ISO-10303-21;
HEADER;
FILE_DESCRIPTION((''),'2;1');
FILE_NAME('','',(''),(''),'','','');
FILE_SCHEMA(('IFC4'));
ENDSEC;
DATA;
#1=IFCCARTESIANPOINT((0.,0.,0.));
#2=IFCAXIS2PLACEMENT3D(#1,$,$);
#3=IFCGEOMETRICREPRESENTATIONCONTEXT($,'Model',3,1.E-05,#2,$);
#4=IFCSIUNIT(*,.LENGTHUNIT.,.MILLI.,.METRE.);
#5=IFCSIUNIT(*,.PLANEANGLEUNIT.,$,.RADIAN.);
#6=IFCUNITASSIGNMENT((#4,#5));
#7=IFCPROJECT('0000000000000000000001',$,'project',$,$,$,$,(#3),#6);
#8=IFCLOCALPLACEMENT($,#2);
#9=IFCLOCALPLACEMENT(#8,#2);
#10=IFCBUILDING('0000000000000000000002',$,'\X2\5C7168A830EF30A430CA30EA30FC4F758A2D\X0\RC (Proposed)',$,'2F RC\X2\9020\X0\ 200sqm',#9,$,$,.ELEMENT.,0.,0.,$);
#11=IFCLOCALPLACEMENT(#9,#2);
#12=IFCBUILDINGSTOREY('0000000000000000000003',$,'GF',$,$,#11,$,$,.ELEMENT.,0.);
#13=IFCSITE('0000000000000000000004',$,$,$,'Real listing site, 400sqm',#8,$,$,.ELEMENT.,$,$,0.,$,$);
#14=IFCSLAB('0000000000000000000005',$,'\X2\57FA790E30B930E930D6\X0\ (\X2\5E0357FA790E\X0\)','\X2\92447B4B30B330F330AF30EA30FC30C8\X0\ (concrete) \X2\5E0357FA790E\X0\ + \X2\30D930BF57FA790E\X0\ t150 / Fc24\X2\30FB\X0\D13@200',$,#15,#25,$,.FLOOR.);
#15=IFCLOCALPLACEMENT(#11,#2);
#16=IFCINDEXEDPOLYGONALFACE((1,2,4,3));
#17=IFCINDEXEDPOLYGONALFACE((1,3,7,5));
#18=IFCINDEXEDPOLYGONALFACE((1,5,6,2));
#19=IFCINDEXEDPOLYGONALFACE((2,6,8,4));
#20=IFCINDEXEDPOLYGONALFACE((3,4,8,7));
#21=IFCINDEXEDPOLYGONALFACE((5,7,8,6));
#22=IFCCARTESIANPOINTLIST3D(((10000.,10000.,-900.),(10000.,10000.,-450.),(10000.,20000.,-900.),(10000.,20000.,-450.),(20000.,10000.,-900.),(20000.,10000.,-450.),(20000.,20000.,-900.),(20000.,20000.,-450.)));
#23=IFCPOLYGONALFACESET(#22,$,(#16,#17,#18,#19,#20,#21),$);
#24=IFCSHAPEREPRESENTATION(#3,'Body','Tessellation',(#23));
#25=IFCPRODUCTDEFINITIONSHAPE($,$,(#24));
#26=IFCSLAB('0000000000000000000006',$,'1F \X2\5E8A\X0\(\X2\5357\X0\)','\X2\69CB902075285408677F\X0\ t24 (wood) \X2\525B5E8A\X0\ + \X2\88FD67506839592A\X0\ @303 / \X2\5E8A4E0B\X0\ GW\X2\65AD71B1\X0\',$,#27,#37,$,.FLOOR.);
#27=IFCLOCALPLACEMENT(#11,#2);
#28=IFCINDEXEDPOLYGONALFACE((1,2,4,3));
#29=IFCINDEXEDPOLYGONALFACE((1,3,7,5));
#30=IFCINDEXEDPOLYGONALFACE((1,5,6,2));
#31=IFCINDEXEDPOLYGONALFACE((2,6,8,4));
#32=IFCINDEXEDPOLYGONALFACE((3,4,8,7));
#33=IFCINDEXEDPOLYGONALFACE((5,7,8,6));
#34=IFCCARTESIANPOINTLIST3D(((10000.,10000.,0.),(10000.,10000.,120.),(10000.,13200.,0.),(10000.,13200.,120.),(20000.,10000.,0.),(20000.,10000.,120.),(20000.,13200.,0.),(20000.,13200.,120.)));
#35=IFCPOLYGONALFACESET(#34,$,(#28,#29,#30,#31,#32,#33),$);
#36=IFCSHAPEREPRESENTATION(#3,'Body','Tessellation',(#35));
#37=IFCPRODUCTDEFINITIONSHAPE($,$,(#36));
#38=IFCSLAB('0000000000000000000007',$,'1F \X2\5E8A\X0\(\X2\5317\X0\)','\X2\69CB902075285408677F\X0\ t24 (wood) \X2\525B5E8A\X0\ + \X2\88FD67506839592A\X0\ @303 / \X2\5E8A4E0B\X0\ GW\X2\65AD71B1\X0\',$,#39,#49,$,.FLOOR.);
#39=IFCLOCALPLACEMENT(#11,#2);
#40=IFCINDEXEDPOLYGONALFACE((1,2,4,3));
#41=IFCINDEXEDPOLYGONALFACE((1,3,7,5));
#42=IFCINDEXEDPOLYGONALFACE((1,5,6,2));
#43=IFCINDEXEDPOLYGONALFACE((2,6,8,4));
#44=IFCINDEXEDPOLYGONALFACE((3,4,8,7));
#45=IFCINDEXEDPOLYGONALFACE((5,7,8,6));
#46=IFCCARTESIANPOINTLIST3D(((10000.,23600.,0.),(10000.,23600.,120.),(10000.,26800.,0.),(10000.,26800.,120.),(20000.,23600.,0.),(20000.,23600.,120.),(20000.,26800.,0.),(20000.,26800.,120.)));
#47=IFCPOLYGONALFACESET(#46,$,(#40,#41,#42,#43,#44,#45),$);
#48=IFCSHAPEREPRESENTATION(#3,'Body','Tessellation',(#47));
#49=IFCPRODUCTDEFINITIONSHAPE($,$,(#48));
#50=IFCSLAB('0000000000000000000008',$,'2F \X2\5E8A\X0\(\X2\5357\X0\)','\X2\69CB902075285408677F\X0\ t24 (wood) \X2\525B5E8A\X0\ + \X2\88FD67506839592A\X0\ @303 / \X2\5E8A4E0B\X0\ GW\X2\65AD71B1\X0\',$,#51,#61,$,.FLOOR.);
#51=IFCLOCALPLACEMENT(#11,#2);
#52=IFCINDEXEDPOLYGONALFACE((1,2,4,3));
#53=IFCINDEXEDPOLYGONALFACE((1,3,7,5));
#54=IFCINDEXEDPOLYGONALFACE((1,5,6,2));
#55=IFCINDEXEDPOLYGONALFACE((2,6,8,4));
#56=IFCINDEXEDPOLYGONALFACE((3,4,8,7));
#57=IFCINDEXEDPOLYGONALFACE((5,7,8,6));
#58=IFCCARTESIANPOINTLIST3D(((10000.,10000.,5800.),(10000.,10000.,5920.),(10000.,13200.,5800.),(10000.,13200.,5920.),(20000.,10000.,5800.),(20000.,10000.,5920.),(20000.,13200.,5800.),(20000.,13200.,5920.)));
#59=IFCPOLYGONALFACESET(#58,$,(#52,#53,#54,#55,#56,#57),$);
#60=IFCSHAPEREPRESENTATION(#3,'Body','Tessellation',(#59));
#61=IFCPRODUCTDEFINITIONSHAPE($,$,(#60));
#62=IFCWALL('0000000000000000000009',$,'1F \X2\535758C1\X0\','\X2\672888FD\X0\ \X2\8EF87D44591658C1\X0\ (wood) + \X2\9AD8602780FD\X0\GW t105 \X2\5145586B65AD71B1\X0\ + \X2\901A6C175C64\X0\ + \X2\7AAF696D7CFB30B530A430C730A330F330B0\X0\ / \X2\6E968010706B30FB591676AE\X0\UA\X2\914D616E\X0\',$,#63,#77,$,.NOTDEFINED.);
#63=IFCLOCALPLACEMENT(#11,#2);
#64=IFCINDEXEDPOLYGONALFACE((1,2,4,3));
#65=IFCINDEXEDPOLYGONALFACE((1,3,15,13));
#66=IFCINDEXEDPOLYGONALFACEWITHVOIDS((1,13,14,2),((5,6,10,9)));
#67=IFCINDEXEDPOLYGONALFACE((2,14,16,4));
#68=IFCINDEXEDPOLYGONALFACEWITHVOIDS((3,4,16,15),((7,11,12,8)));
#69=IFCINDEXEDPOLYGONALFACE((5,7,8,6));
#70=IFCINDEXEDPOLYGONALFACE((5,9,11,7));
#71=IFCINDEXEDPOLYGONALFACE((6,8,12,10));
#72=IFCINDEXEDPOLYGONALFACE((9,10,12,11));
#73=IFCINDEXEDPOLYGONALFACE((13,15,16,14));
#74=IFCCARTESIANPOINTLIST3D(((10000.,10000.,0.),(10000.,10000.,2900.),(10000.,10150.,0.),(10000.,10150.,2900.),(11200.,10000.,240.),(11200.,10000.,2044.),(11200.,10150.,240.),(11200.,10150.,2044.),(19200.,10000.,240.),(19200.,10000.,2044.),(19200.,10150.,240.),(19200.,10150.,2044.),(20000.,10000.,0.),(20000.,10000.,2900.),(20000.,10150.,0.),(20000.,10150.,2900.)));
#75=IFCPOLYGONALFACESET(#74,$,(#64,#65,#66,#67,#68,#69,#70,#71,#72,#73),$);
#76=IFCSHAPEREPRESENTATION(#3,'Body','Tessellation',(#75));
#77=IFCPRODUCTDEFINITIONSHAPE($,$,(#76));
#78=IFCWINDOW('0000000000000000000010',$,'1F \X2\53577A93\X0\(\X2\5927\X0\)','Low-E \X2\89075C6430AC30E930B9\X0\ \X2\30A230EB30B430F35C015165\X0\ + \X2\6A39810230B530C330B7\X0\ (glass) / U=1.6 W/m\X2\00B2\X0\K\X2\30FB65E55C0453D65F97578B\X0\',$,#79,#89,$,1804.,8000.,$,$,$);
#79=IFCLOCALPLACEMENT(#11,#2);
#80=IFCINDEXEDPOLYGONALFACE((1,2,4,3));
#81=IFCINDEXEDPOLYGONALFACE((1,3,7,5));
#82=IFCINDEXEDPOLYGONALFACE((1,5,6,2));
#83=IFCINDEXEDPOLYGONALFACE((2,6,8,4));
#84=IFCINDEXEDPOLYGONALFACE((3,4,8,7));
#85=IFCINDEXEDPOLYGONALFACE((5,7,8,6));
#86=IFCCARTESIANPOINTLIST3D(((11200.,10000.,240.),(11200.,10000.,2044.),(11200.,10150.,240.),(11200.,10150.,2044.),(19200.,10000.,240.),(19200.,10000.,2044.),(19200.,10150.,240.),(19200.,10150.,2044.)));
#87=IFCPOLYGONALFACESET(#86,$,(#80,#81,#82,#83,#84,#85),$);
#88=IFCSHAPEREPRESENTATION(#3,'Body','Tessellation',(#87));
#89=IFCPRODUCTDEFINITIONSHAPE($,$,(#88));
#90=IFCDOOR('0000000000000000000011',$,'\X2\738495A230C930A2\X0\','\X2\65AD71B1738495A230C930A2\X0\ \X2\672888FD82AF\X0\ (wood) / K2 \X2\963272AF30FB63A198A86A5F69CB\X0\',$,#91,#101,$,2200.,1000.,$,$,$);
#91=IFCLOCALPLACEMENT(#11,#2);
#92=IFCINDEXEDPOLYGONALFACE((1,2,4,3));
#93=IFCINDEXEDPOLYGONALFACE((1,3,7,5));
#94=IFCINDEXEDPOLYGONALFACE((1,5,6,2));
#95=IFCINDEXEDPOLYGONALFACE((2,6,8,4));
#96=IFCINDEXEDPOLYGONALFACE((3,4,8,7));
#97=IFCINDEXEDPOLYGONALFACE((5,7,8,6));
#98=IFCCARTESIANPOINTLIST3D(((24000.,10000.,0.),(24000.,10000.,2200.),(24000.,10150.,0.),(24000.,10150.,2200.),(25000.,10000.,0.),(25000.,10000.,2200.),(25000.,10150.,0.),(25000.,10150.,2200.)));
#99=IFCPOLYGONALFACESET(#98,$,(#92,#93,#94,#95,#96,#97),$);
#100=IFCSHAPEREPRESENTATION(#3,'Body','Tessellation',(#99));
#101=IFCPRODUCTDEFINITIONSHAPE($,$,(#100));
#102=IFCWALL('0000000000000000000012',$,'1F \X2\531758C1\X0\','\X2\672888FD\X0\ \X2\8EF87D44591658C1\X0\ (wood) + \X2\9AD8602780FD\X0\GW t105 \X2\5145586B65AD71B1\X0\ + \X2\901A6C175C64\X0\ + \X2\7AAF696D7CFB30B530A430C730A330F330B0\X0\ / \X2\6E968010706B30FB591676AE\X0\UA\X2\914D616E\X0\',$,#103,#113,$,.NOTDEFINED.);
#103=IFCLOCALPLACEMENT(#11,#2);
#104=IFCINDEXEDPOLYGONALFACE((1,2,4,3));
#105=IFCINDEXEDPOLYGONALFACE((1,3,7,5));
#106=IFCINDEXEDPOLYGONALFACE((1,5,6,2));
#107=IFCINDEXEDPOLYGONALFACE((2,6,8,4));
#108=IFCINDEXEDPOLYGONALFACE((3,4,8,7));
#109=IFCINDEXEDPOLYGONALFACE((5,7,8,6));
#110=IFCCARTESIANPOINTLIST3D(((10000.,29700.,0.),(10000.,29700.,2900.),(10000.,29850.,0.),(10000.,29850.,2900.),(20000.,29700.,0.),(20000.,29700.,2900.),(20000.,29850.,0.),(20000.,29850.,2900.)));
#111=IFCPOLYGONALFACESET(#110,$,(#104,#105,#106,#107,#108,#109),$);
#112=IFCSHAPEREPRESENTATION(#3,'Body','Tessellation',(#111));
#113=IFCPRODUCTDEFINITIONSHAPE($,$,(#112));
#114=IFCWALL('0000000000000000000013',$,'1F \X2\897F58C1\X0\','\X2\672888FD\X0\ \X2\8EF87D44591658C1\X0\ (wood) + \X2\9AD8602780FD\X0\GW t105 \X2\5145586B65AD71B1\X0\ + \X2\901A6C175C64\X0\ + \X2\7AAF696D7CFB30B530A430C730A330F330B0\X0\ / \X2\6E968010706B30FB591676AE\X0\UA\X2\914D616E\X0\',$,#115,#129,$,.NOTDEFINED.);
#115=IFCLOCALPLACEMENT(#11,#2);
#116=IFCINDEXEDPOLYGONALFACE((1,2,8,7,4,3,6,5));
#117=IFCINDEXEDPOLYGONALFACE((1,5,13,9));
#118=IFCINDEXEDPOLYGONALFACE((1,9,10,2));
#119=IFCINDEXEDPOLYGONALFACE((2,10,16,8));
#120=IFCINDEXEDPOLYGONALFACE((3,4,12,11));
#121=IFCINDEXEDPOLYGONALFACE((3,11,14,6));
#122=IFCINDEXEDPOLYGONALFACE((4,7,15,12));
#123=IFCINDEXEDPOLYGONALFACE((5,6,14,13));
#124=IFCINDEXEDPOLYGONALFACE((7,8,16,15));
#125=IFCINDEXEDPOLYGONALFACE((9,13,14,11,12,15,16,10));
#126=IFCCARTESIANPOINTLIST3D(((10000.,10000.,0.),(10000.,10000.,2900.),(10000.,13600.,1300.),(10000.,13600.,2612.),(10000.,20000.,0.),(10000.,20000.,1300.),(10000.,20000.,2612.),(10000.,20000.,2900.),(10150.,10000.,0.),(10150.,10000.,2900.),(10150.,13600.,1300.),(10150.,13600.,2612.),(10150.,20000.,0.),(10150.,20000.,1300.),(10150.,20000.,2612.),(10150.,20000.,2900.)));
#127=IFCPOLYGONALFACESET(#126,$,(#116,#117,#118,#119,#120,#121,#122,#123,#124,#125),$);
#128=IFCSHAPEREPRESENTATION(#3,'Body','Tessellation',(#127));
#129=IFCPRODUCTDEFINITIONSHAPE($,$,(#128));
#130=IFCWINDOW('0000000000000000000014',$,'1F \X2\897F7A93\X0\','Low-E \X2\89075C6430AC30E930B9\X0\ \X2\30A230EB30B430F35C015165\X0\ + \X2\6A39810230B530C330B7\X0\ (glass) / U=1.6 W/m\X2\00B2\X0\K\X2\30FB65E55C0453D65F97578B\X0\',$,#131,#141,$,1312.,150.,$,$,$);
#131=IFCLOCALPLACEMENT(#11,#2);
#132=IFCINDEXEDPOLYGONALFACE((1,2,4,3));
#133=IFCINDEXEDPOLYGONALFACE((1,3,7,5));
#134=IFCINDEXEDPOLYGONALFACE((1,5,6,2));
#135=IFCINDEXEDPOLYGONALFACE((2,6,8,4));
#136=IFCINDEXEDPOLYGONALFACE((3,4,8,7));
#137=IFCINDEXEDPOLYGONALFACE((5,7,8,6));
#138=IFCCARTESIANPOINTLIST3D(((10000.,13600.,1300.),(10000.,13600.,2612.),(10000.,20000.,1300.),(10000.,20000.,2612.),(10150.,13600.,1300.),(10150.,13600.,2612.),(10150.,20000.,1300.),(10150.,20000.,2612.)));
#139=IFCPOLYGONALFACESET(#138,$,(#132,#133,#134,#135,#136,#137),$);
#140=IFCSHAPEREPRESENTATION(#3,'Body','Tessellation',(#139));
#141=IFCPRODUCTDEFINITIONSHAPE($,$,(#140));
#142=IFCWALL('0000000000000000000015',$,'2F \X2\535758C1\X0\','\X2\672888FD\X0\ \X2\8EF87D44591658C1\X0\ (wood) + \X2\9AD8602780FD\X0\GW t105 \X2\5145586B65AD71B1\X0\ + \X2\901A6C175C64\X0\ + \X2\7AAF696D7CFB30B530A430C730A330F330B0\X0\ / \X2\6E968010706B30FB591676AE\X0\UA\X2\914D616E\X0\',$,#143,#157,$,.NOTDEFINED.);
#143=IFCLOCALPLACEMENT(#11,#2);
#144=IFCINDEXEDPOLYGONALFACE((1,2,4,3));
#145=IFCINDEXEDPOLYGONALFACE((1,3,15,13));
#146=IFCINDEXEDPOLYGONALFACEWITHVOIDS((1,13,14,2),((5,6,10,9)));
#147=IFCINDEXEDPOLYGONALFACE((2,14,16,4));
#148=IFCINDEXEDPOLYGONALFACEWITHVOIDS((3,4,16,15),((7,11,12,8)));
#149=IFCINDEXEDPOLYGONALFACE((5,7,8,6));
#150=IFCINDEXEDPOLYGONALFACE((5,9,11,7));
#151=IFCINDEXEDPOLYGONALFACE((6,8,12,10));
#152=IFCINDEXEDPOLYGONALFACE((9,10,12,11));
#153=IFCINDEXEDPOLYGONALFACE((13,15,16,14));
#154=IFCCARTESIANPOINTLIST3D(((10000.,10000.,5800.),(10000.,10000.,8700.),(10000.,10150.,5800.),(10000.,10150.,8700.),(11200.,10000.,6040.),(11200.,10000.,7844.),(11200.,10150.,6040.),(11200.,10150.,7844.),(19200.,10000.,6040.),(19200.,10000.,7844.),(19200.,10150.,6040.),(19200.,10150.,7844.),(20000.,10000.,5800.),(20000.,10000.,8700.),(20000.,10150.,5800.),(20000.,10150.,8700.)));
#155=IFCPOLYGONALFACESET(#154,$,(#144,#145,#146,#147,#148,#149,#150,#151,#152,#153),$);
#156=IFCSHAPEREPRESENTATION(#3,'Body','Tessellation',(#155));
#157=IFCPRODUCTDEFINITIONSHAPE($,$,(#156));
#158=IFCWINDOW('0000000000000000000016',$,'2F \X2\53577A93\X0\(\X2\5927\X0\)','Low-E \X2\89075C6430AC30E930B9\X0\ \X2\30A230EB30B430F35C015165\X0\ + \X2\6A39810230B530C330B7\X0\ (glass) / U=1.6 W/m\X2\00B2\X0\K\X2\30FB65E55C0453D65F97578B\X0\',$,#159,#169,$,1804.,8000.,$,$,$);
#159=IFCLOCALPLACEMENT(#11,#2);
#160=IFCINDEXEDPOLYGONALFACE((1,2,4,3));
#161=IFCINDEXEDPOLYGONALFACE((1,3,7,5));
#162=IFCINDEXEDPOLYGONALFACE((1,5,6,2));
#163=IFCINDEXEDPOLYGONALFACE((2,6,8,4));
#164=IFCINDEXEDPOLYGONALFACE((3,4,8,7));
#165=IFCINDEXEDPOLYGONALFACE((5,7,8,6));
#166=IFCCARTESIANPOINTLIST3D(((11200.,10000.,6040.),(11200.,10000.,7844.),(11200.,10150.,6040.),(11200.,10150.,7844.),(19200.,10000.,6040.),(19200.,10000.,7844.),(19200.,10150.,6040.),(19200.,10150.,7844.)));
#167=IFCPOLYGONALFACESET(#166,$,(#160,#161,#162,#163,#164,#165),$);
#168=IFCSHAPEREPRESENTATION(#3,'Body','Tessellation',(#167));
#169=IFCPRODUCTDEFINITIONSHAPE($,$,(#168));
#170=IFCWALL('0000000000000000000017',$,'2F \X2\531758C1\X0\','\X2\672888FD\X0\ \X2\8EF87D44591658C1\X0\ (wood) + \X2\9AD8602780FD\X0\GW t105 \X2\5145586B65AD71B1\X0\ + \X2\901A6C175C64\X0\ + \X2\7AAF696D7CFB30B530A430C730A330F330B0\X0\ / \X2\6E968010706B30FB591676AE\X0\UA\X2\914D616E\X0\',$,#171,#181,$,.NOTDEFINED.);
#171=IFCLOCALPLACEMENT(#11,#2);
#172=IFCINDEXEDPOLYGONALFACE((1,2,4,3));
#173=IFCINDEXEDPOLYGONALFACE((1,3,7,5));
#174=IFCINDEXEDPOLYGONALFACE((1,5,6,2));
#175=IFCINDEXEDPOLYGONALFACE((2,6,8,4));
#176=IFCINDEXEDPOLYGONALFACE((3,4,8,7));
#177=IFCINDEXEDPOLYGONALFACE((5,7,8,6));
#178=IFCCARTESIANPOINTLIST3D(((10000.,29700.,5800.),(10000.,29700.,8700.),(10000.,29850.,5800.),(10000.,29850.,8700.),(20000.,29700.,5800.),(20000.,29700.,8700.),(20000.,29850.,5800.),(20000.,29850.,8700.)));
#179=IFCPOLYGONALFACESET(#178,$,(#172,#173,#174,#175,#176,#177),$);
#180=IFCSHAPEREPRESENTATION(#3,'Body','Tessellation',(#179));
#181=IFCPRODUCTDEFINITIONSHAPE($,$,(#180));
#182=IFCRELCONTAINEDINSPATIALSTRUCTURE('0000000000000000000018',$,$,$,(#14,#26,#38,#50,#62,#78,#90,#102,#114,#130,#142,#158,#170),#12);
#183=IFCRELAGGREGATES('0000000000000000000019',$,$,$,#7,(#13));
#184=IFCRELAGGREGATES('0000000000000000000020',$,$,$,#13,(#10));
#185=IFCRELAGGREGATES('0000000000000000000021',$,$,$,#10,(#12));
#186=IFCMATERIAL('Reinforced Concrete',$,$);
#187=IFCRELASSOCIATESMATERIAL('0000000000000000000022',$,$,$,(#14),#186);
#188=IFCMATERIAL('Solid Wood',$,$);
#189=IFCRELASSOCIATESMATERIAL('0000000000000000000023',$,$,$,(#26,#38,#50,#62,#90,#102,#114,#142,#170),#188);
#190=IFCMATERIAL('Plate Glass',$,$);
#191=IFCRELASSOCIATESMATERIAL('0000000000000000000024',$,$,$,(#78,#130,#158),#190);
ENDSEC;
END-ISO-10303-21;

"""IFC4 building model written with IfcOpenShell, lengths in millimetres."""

from ifc_helpers import new_model, si_unit, frame, frame_2d, origin, place, context, project, spatial, rectangle, extrude, material, element, fill, save


model = new_model("IFC4")

# Units and contexts
model_context = context("Model", 3, precision=1e-05, world=origin())
ifc_project = project(units=[si_unit("LENGTHUNIT", "METRE", prefix="MILLI"), si_unit("PLANEANGLEUNIT", "RADIAN")], contexts=[model_context])

# Site, building, storey
site_placement = place(None, origin())
site = spatial("IfcSite", under=ifc_project, at=site_placement, ObjectType="Real listing site, 400sqm", CompositionType="ELEMENT", RefElevation=0.0)
building_placement = place(site_placement, origin())
building = spatial("IfcBuilding", under=site, at=building_placement, Name="山梨ワイナリー併設RC (Proposed)", ObjectType="2F RC造 200sqm", CompositionType="ELEMENT", ElevationOfRefHeight=0.0, ElevationOfTerrain=0.0)
storey_placement = place(building_placement, origin())
storey = spatial("IfcBuildingStorey", under=building, at=storey_placement, Name="GF", CompositionType="ELEMENT", Elevation=0.0)

# Slabs
ifc_material_1 = material(Name="Reinforced Concrete")
slab_1_placement = place(storey_placement, frame((5000.0, 5000.0, -450.0)))
element("IfcSlab", 1, at=slab_1_placement, inside=storey, material=ifc_material_1, Name="基礎スラブ (布基礎)", Description="鉄筋コンクリート (concrete) 布基礎 + ベタ基礎 t150 / Fc24・D13@200", PredefinedType="FLOOR", context=model_context, shape_type="SweptSolid", body=[
    extrude(rectangle(XDim=10000.0, YDim=10000.0, at=frame_2d((5000.0, 5000.0))), frame((5000.0, 5000.0, -450.0)), (0.0, 0.0, 1.0), 450.0),
])
ifc_material_2 = material(Name="Solid Wood")
slab_2_placement = place(storey_placement, frame((5000.0, 5000.0, 0.0)))
element("IfcSlab", 2, at=slab_2_placement, inside=storey, material=ifc_material_2, Name="1F 床(南)", Description="構造用合板 t24 (wood) 剛床 + 製材根太 @303 / 床下 GW断熱", PredefinedType="FLOOR", context=model_context, shape_type="SweptSolid", body=[
    extrude(rectangle(XDim=10000.0, YDim=3200.0, at=frame_2d((5000.0, 1600.0))), frame((5000.0, 5000.0, 0.0)), (0.0, 0.0, 1.0), 120.0),
])
slab_3_placement = place(storey_placement, frame((5000.0, 11800.0, 0.0)))
element("IfcSlab", 3, at=slab_3_placement, inside=storey, material=ifc_material_2, Name="1F 床(北)", Description="構造用合板 t24 (wood) 剛床 + 製材根太 @303 / 床下 GW断熱", PredefinedType="FLOOR", context=model_context, shape_type="SweptSolid", body=[
    extrude(rectangle(XDim=10000.0, YDim=3200.0, at=frame_2d((5000.0, 1600.0))), frame((5000.0, 11800.0, 0.0)), (0.0, 0.0, 1.0), 120.0),
])
slab_4_placement = place(storey_placement, frame((5000.0, 5000.0, 2900.0)))
element("IfcSlab", 4, at=slab_4_placement, inside=storey, material=ifc_material_2, Name="2F 床(南)", Description="構造用合板 t24 (wood) 剛床 + 製材根太 @303 / 床下 GW断熱", PredefinedType="FLOOR", context=model_context, shape_type="SweptSolid", body=[
    extrude(rectangle(XDim=10000.0, YDim=3200.0, at=frame_2d((5000.0, 1600.0))), frame((5000.0, 5000.0, 2900.0)), (0.0, 0.0, 1.0), 120.0),
])

# Wall, openings, window, door
wall_1_placement = place(storey_placement, frame((5000.0, 5000.0, 0.0)))
wall_1 = element("IfcWall", 5, at=wall_1_placement, inside=storey, material=ifc_material_2, Name="1F 南壁", Description="木製 軸組外壁 (wood) + 高性能GW t105 充填断熱 + 通気層 + 窯業系サイディング / 準耐火・外皮UA配慮", PredefinedType="NOTDEFINED", context=model_context, shape_type="SweptSolid", body=[
    extrude(rectangle(XDim=10000.0, YDim=150.0, at=frame_2d((5000.0, 75.0))), frame((5000.0, 5000.0, 0.0)), (0.0, 0.0, 1.0), 2900.0),
])
opening_1_placement = place(storey_placement, frame((5600.0, 5000.0, 120.0)))
opening_1 = element("IfcOpeningElement", 6, at=opening_1_placement, cuts=wall_1, PredefinedType="NOTDEFINED", context=model_context, shape_type="SweptSolid", body=[
    extrude(rectangle(XDim=8000.0, YDim=150.0, at=frame_2d((4000.0, 75.0))), frame((5600.0, 5000.0, 120.0)), (0.0, 0.0, 1.0), 1804.0),
])
opening_2_placement = place(storey_placement, frame((12000.0, 5000.0, 0.0)))
opening_2 = element("IfcOpeningElement", 7, at=opening_2_placement, cuts=wall_1, PredefinedType="NOTDEFINED", context=model_context, shape_type="SweptSolid", body=[
    extrude(rectangle(XDim=1000.0, YDim=150.0, at=frame_2d((500.0, 75.0))), frame((12000.0, 5000.0, 0.0)), (0.0, 0.0, 1.0), 2200.0),
])
ifc_material_3 = material(Name="Plate Glass")
window_1_placement = place(storey_placement, frame((5600.0, 5000.0, 120.0)))
window_1 = element("IfcWindow", 8, at=window_1_placement, inside=storey, material=ifc_material_3, Name="1F 南窓(大)", Description="Low-E 複層ガラス アルゴン封入 + 樹脂サッシ (glass) / U=1.6 W/m²K・日射取得型", OverallHeight=1804.0, OverallWidth=8000.0, context=model_context, shape_type="SweptSolid", body=[
    extrude(rectangle(XDim=8000.0, YDim=150.0, at=frame_2d((4000.0, 75.0))), frame((5600.0, 5000.0, 120.0)), (0.0, 0.0, 1.0), 1804.0),
])
fill(opening_1, window_1)
door_placement = place(storey_placement, frame((12000.0, 5000.0, 0.0)))
door = element("IfcDoor", 9, at=door_placement, inside=storey, material=ifc_material_2, Name="玄関ドア", Description="断熱玄関ドア 木製芯 (wood) / K2 防犯・採風機構", OverallHeight=2200.0, OverallWidth=1000.0, context=model_context, shape_type="SweptSolid", body=[
    extrude(rectangle(XDim=1000.0, YDim=150.0, at=frame_2d((500.0, 75.0))), frame((12000.0, 5000.0, 0.0)), (0.0, 0.0, 1.0), 2200.0),
])
fill(opening_2, door)

# Wall
wall_2_placement = place(storey_placement, frame((5000.0, 14850.0, 0.0)))
element("IfcWall", 10, at=wall_2_placement, inside=storey, material=ifc_material_2, Name="1F 北壁", Description="木製 軸組外壁 (wood) + 高性能GW t105 充填断熱 + 通気層 + 窯業系サイディング / 準耐火・外皮UA配慮", PredefinedType="NOTDEFINED", context=model_context, shape_type="SweptSolid", body=[
    extrude(rectangle(XDim=10000.0, YDim=150.0, at=frame_2d((5000.0, 75.0))), frame((5000.0, 14850.0, 0.0)), (0.0, 0.0, 1.0), 2900.0),
])

# Walls, openings, windows
wall_3_placement = place(storey_placement, frame((5000.0, 5000.0, 0.0)))
wall_3 = element("IfcWall", 11, at=wall_3_placement, inside=storey, material=ifc_material_2, Name="1F 西壁", Description="木製 軸組外壁 (wood) + 高性能GW t105 充填断熱 + 通気層 + 窯業系サイディング / 準耐火・外皮UA配慮", PredefinedType="NOTDEFINED", context=model_context, shape_type="SweptSolid", body=[
    extrude(rectangle(XDim=150.0, YDim=10000.0, at=frame_2d((75.0, 5000.0))), frame((5000.0, 5000.0, 0.0)), (0.0, 0.0, 1.0), 2900.0),
])
opening_3_placement = place(storey_placement, frame((5000.0, 6800.0, 650.0)))
opening_3 = element("IfcOpeningElement", 12, at=opening_3_placement, cuts=wall_3, PredefinedType="NOTDEFINED", context=model_context, shape_type="SweptSolid", body=[
    extrude(rectangle(XDim=150.0, YDim=6400.0, at=frame_2d((75.0, 3200.0))), frame((5000.0, 6800.0, 650.0)), (0.0, 0.0, 1.0), 1312.0),
])
window_2_placement = place(storey_placement, frame((5000.0, 6800.0, 650.0)))
window_2 = element("IfcWindow", 13, at=window_2_placement, inside=storey, material=ifc_material_3, Name="1F 西窓", Description="Low-E 複層ガラス アルゴン封入 + 樹脂サッシ (glass) / U=1.6 W/m²K・日射取得型", OverallHeight=1312.0, OverallWidth=150.0, context=model_context, shape_type="SweptSolid", body=[
    extrude(rectangle(XDim=150.0, YDim=6400.0, at=frame_2d((75.0, 3200.0))), frame((5000.0, 6800.0, 650.0)), (0.0, 0.0, 1.0), 1312.0),
])
fill(opening_3, window_2)
wall_4_placement = place(storey_placement, frame((5000.0, 5000.0, 2900.0)))
wall_4 = element("IfcWall", 14, at=wall_4_placement, inside=storey, material=ifc_material_2, Name="2F 南壁", Description="木製 軸組外壁 (wood) + 高性能GW t105 充填断熱 + 通気層 + 窯業系サイディング / 準耐火・外皮UA配慮", PredefinedType="NOTDEFINED", context=model_context, shape_type="SweptSolid", body=[
    extrude(rectangle(XDim=10000.0, YDim=150.0, at=frame_2d((5000.0, 75.0))), frame((5000.0, 5000.0, 2900.0)), (0.0, 0.0, 1.0), 2900.0),
])
opening_4_placement = place(storey_placement, frame((5600.0, 5000.0, 3020.0)))
opening_4 = element("IfcOpeningElement", 15, at=opening_4_placement, cuts=wall_4, PredefinedType="NOTDEFINED", context=model_context, shape_type="SweptSolid", body=[
    extrude(rectangle(XDim=8000.0, YDim=150.0, at=frame_2d((4000.0, 75.0))), frame((5600.0, 5000.0, 3020.0)), (0.0, 0.0, 1.0), 1804.0),
])
window_3_placement = place(storey_placement, frame((5600.0, 5000.0, 3020.0)))
window_3 = element("IfcWindow", 16, at=window_3_placement, inside=storey, material=ifc_material_3, Name="2F 南窓(大)", Description="Low-E 複層ガラス アルゴン封入 + 樹脂サッシ (glass) / U=1.6 W/m²K・日射取得型", OverallHeight=1804.0, OverallWidth=8000.0, context=model_context, shape_type="SweptSolid", body=[
    extrude(rectangle(XDim=8000.0, YDim=150.0, at=frame_2d((4000.0, 75.0))), frame((5600.0, 5000.0, 3020.0)), (0.0, 0.0, 1.0), 1804.0),
])
fill(opening_4, window_3)

# Wall
wall_5_placement = place(storey_placement, frame((5000.0, 14850.0, 2900.0)))
element("IfcWall", 17, at=wall_5_placement, inside=storey, material=ifc_material_2, Name="2F 北壁", Description="木製 軸組外壁 (wood) + 高性能GW t105 充填断熱 + 通気層 + 窯業系サイディング / 準耐火・外皮UA配慮", PredefinedType="NOTDEFINED", context=model_context, shape_type="SweptSolid", body=[
    extrude(rectangle(XDim=10000.0, YDim=150.0, at=frame_2d((5000.0, 75.0))), frame((5000.0, 14850.0, 2900.0)), (0.0, 0.0, 1.0), 2900.0),
])

save(model, "model.ifc")
